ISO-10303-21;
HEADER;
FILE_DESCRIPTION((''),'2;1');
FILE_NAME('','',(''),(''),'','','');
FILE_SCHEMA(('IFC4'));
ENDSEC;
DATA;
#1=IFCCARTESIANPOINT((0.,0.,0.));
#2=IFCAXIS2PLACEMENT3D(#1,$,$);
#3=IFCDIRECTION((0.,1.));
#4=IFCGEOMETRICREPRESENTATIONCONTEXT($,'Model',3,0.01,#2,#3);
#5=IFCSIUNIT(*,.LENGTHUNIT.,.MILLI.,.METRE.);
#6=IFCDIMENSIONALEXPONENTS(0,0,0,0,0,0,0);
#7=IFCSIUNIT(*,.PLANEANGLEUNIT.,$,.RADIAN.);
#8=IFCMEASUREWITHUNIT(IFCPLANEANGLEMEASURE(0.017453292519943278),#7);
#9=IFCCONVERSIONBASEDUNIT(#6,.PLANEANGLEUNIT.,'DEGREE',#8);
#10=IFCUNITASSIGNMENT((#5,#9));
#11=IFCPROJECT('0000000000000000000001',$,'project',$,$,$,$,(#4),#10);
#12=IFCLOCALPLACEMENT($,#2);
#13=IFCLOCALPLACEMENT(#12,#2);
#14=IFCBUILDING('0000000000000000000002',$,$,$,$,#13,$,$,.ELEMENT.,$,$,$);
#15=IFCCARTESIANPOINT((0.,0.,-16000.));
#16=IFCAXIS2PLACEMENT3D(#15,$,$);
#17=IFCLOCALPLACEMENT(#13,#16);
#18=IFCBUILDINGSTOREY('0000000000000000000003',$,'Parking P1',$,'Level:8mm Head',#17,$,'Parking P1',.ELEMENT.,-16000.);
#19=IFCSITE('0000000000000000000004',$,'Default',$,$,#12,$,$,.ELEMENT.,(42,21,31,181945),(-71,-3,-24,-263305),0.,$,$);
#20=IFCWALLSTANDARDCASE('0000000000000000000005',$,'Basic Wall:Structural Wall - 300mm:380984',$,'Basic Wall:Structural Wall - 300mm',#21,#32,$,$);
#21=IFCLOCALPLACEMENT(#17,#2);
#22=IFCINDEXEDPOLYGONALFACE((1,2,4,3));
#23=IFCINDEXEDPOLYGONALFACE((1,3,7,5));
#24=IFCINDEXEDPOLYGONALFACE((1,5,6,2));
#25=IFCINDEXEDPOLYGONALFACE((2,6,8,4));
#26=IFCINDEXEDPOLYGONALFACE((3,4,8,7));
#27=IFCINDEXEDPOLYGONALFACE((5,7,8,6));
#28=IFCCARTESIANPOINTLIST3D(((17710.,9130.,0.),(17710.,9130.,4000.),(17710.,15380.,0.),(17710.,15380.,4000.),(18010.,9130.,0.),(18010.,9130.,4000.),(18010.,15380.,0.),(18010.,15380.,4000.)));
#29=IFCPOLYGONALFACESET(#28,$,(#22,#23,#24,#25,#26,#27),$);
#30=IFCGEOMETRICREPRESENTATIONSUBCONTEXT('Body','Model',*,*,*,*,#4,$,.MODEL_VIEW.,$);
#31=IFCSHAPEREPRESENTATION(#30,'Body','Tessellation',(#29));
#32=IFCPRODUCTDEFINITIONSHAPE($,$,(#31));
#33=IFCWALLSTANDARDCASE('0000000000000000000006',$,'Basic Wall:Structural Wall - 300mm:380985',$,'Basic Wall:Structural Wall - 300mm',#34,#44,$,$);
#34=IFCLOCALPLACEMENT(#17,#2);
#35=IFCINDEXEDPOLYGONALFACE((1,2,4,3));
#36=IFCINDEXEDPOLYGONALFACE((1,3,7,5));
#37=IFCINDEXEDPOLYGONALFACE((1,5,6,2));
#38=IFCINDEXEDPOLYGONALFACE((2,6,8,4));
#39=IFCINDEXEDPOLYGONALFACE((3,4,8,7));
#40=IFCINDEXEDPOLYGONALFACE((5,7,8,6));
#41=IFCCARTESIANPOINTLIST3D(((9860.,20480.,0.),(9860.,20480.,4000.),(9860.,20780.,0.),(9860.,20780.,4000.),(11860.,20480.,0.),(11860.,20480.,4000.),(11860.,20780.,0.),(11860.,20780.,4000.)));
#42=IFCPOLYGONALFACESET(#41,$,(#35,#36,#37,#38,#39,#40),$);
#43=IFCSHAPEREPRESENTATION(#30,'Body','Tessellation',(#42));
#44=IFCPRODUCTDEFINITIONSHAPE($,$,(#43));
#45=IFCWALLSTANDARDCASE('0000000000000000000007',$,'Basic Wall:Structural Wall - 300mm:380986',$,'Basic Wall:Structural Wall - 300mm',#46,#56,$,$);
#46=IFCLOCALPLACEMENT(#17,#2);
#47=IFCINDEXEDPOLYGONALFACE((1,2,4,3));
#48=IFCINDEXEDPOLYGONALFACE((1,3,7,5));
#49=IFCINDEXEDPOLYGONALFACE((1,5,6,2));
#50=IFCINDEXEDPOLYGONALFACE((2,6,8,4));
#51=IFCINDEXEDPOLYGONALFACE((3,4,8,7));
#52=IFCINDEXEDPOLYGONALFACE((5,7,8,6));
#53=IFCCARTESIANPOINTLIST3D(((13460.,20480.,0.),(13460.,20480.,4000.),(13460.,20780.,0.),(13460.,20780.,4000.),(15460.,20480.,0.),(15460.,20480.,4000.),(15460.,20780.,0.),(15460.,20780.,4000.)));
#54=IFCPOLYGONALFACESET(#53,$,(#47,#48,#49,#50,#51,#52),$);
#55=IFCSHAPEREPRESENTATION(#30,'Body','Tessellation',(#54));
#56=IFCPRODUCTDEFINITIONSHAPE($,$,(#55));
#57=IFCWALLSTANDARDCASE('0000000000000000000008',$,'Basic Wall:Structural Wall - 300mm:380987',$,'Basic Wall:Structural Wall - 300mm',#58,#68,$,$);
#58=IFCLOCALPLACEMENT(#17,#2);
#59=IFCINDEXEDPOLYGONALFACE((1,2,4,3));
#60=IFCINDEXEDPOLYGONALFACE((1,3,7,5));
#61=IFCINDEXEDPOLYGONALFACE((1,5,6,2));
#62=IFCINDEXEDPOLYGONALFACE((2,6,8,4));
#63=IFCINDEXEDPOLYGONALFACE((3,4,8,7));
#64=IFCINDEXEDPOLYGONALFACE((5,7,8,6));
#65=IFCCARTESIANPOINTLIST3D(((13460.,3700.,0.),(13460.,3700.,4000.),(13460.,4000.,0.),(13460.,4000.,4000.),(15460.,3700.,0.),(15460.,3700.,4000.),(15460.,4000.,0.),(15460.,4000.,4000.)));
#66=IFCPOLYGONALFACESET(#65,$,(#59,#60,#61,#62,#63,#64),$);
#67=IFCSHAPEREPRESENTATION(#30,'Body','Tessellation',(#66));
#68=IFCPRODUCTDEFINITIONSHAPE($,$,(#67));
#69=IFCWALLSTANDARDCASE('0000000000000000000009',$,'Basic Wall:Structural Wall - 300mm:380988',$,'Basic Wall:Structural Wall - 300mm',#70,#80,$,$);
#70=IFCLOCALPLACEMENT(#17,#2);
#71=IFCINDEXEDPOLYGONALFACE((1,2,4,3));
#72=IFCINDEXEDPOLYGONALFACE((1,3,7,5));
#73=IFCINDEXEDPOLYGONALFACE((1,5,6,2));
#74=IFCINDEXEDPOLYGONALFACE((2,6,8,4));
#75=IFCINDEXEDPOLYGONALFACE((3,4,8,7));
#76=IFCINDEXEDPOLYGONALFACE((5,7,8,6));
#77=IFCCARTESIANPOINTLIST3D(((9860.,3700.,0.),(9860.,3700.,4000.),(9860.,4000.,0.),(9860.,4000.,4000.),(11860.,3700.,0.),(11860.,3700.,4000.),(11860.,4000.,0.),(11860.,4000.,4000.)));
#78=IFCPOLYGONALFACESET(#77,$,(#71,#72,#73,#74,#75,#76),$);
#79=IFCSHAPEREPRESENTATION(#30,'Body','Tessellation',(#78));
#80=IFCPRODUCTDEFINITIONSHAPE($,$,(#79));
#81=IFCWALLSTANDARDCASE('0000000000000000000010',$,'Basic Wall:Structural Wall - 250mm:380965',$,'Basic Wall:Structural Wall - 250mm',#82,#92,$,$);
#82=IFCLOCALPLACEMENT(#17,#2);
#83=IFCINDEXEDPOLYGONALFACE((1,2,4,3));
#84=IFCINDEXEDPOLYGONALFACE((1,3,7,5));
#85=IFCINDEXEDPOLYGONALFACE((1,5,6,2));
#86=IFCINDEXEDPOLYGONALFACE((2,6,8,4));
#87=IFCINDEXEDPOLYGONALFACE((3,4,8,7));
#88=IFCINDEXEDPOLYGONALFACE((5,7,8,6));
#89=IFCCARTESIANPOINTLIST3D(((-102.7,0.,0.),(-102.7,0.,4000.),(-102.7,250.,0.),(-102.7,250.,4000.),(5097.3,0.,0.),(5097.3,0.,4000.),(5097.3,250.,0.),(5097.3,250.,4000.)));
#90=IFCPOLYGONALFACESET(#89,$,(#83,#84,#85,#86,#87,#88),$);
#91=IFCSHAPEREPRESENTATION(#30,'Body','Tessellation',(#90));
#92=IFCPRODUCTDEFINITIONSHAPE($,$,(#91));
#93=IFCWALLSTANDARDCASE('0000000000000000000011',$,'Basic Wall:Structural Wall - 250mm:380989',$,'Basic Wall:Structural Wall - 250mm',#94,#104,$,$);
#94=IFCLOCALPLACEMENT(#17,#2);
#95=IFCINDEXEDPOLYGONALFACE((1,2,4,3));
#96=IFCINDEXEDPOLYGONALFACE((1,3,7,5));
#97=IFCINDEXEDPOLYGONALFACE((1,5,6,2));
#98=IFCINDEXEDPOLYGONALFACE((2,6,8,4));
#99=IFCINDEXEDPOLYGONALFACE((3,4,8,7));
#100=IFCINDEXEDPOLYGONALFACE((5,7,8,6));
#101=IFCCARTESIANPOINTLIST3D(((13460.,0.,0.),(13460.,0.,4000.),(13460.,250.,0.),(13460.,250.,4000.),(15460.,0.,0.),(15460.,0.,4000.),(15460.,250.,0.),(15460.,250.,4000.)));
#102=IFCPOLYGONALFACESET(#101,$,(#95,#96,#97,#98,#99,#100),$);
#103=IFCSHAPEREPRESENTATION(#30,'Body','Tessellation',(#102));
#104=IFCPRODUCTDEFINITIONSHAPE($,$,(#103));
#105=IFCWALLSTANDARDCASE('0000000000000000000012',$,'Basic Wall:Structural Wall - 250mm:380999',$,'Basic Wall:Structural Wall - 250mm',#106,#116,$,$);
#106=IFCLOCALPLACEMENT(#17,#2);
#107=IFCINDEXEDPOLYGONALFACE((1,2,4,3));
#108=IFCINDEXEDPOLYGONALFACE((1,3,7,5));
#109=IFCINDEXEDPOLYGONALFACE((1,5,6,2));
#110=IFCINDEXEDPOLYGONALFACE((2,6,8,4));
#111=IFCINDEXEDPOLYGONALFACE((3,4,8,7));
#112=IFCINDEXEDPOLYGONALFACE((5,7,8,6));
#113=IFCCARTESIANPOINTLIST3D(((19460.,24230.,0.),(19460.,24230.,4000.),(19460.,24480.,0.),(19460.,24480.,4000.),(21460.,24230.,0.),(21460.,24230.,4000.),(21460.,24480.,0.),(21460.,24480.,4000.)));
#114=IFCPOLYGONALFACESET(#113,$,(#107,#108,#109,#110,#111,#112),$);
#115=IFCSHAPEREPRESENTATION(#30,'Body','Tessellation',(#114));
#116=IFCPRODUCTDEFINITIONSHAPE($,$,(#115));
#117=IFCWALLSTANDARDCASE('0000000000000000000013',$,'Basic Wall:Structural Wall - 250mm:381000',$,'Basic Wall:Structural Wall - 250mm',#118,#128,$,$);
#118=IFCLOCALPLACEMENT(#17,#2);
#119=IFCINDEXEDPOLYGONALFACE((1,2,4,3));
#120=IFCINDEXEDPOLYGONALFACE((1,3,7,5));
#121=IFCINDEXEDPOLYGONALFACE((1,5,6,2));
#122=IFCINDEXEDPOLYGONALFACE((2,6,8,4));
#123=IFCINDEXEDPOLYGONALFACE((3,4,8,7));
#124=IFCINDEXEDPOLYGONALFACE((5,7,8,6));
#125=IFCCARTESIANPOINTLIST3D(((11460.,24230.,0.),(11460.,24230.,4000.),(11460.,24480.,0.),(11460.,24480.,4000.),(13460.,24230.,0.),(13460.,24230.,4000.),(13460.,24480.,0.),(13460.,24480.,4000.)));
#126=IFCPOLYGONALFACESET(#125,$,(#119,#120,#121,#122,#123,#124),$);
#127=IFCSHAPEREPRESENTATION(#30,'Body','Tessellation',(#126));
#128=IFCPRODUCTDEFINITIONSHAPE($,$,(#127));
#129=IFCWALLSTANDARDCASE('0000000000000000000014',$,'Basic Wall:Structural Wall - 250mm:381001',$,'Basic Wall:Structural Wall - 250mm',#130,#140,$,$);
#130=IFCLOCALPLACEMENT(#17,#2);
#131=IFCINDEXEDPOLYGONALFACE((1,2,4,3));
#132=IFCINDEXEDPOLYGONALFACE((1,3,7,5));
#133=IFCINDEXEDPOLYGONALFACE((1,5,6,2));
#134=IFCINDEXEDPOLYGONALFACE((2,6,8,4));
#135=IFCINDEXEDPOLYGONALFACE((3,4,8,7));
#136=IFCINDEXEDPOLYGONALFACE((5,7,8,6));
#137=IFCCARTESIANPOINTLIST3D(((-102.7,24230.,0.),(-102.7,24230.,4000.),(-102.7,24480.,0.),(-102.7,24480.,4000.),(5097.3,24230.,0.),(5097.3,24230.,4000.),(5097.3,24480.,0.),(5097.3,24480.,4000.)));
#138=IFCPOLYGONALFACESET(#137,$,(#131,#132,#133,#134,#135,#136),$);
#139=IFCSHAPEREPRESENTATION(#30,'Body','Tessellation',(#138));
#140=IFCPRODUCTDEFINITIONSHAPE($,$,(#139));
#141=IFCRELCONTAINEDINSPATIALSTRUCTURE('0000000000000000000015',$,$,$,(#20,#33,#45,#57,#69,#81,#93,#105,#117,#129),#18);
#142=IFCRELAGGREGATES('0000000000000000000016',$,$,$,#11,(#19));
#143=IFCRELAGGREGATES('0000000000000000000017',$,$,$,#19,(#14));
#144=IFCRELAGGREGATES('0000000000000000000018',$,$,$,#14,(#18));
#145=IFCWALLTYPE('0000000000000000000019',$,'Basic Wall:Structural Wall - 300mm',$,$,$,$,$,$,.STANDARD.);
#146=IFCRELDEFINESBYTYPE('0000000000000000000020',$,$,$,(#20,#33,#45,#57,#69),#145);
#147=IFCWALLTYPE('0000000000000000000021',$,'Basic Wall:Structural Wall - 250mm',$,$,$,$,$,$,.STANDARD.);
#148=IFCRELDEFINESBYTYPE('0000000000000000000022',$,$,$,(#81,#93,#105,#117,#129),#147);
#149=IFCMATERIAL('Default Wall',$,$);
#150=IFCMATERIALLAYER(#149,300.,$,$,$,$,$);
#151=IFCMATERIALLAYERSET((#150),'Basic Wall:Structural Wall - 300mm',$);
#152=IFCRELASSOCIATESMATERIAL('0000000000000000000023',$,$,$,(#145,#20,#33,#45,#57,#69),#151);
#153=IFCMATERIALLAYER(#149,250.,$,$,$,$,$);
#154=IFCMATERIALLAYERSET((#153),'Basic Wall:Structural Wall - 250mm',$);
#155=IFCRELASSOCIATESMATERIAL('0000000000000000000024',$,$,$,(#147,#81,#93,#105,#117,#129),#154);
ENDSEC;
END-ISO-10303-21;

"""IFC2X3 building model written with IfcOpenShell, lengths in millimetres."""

from ifc_helpers import new_model, entity, si_unit, converted_unit, direction, frame, frame_2d, origin, place, context, subcontext, project, spatial, rectangle, extrude, material, layer, layer_set, layer_usage, type_object, element, save


model = new_model("IFC2X3")

# Units and contexts
model_context = context("Model", 3, precision=0.01, world=origin(), true_north=direction((0.0, 1.0)))
body_context = subcontext(model_context, "Body", "Model", "MODEL_VIEW")
ifc_project = project(units=[si_unit("LENGTHUNIT", "METRE", prefix="MILLI"), converted_unit("PLANEANGLEUNIT", "DEGREE", entity("IfcPlaneAngleMeasure", 0.017453292519943278), si_unit("PLANEANGLEUNIT", "RADIAN"), dimensions=[0, 0, 0, 0, 0, 0, 0])], contexts=[model_context])

# Site, building, storey
site_placement = place(None, origin())
site = spatial("IfcSite", under=ifc_project, at=site_placement, Name="Default", CompositionType="ELEMENT", RefLatitude=(42, 21, 31, 181945), RefLongitude=(-71, -3, -24, -263305), RefElevation=0.0)
building_placement = place(site_placement, origin())
building = spatial("IfcBuilding", under=site, at=building_placement, CompositionType="ELEMENT")
storey_placement = place(building_placement, frame((0.0, 0.0, -16000.0)))
storey = spatial("IfcBuildingStorey", under=building, at=storey_placement, Name="Parking P1", ObjectType="Level:8mm Head", LongName="Parking P1", CompositionType="ELEMENT", Elevation=-16000.0)

# Walls
ifc_material_1 = material(Name="Default Wall")
ifc_layer_1 = layer(ifc_material_1, 300.0)
ifc_layer_set_1 = layer_set([ifc_layer_1], Name="Basic Wall:Structural Wall - 300mm")
wall_type_1 = type_object("IfcWallType", Name="Basic Wall:Structural Wall - 300mm", PredefinedType="STANDARD", material=ifc_layer_set_1)
ifc_layer_usage_1 = layer_usage(ifc_layer_set_1, "AXIS2", "NEGATIVE", 150.0)
wall_1_placement = place(storey_placement, frame((17860.0, 15380.0, 0.0), z_axis=(0.0, 0.0, 1.0), x_axis=(0.0, -1.0, 0.0)))
element("IfcWallStandardCase", 1, at=wall_1_placement, inside=storey, type_object=wall_type_1, material=ifc_layer_usage_1, Name="Basic Wall:Structural Wall - 300mm:380984", ObjectType="Basic Wall:Structural Wall - 300mm", context=body_context, shape_type="SweptSolid", body=[
    extrude(rectangle(XDim=6250.0, YDim=300.0, at=frame_2d((3125.0, 0.0), x_axis=(-1.0, 0.0))), origin(), (0.0, 0.0, 1.0), 4000.0),
])
ifc_layer_usage_2 = layer_usage(ifc_layer_set_1, "AXIS2", "NEGATIVE", 150.0)
wall_2_placement = place(storey_placement, frame((9860.0, 20630.0, 0.0)))
element("IfcWallStandardCase", 2, at=wall_2_placement, inside=storey, type_object=wall_type_1, material=ifc_layer_usage_2, Name="Basic Wall:Structural Wall - 300mm:380985", ObjectType="Basic Wall:Structural Wall - 300mm", context=body_context, shape_type="SweptSolid", body=[
    extrude(rectangle(XDim=2000.0, YDim=300.0, at=frame_2d((1000.0, 0.0), x_axis=(-1.0, 0.0))), origin(), (0.0, 0.0, 1.0), 4000.0),
])
ifc_layer_usage_3 = layer_usage(ifc_layer_set_1, "AXIS2", "NEGATIVE", 150.0)
wall_3_placement = place(storey_placement, frame((13460.0, 20630.0, 0.0)))
element("IfcWallStandardCase", 3, at=wall_3_placement, inside=storey, type_object=wall_type_1, material=ifc_layer_usage_3, Name="Basic Wall:Structural Wall - 300mm:380986", ObjectType="Basic Wall:Structural Wall - 300mm", context=body_context, shape_type="SweptSolid", body=[
    extrude(rectangle(XDim=2000.0, YDim=300.0, at=frame_2d((1000.0, 0.0), x_axis=(-1.0, 0.0))), origin(), (0.0, 0.0, 1.0), 4000.0),
])
ifc_layer_usage_4 = layer_usage(ifc_layer_set_1, "AXIS2", "NEGATIVE", 150.0)
wall_4_placement = place(storey_placement, frame((13460.0, 3850.0, 0.0)))
element("IfcWallStandardCase", 4, at=wall_4_placement, inside=storey, type_object=wall_type_1, material=ifc_layer_usage_4, Name="Basic Wall:Structural Wall - 300mm:380987", ObjectType="Basic Wall:Structural Wall - 300mm", context=body_context, shape_type="SweptSolid", body=[
    extrude(rectangle(XDim=2000.0, YDim=300.0, at=frame_2d((1000.0, 0.0), x_axis=(-1.0, 0.0))), origin(), (0.0, 0.0, 1.0), 4000.0),
])
ifc_layer_usage_5 = layer_usage(ifc_layer_set_1, "AXIS2", "NEGATIVE", 150.0)
wall_5_placement = place(storey_placement, frame((9860.0, 3850.0, 0.0)))
element("IfcWallStandardCase", 5, at=wall_5_placement, inside=storey, type_object=wall_type_1, material=ifc_layer_usage_5, Name="Basic Wall:Structural Wall - 300mm:380988", ObjectType="Basic Wall:Structural Wall - 300mm", context=body_context, shape_type="SweptSolid", body=[
    extrude(rectangle(XDim=2000.0, YDim=300.0, at=frame_2d((1000.0, 0.0), x_axis=(-1.0, 0.0))), origin(), (0.0, 0.0, 1.0), 4000.0),
])
ifc_layer_2 = layer(ifc_material_1, 250.0)
ifc_layer_set_2 = layer_set([ifc_layer_2], Name="Basic Wall:Structural Wall - 250mm")
ifc_layer_usage_6 = layer_usage(ifc_layer_set_2, "AXIS2", "POSITIVE", -125.0)
wall_type_2 = type_object("IfcWallType", Name="Basic Wall:Structural Wall - 250mm", PredefinedType="STANDARD", material=ifc_layer_set_2)
wall_6_placement = place(storey_placement, frame((-102.7, 125.0, 0.0)))
element("IfcWallStandardCase", 6, at=wall_6_placement, inside=storey, type_object=wall_type_2, material=ifc_layer_usage_6, Name="Basic Wall:Structural Wall - 250mm:380965", ObjectType="Basic Wall:Structural Wall - 250mm", context=body_context, shape_type="SweptSolid", body=[
    extrude(rectangle(XDim=5200.0, YDim=250.0, at=frame_2d((2600.0, 0.0), x_axis=(-1.0, 0.0))), origin(), (0.0, 0.0, 1.0), 4000.0),
])
ifc_layer_usage_7 = layer_usage(ifc_layer_set_2, "AXIS2", "NEGATIVE", 125.0)
wall_7_placement = place(storey_placement, frame((15460.0, 125.0, 0.0), z_axis=(0.0, 0.0, 1.0), x_axis=(-1.0, 0.0, 0.0)))
element("IfcWallStandardCase", 7, at=wall_7_placement, inside=storey, type_object=wall_type_2, material=ifc_layer_usage_7, Name="Basic Wall:Structural Wall - 250mm:380989", ObjectType="Basic Wall:Structural Wall - 250mm", context=body_context, shape_type="SweptSolid", body=[
    extrude(rectangle(XDim=2000.0, YDim=250.0, at=frame_2d((1000.0, 0.0), x_axis=(-1.0, 0.0))), origin(), (0.0, 0.0, 1.0), 4000.0),
])
ifc_layer_usage_8 = layer_usage(ifc_layer_set_2, "AXIS2", "NEGATIVE", 125.0)
wall_8_placement = place(storey_placement, frame((19460.0, 24355.0, 0.0)))
element("IfcWallStandardCase", 8, at=wall_8_placement, inside=storey, type_object=wall_type_2, material=ifc_layer_usage_8, Name="Basic Wall:Structural Wall - 250mm:380999", ObjectType="Basic Wall:Structural Wall - 250mm", context=body_context, shape_type="SweptSolid", body=[
    extrude(rectangle(XDim=2000.0, YDim=250.0, at=frame_2d((1000.0, 0.0), x_axis=(-1.0, 0.0))), origin(), (0.0, 0.0, 1.0), 4000.0),
])
ifc_layer_usage_9 = layer_usage(ifc_layer_set_2, "AXIS2", "NEGATIVE", 125.0)
wall_9_placement = place(storey_placement, frame((11460.0, 24355.0, 0.0)))
element("IfcWallStandardCase", 9, at=wall_9_placement, inside=storey, type_object=wall_type_2, material=ifc_layer_usage_9, Name="Basic Wall:Structural Wall - 250mm:381000", ObjectType="Basic Wall:Structural Wall - 250mm", context=body_context, shape_type="SweptSolid", body=[
    extrude(rectangle(XDim=2000.0, YDim=250.0, at=frame_2d((1000.0, 0.0), x_axis=(-1.0, 0.0))), origin(), (0.0, 0.0, 1.0), 4000.0),
])
ifc_layer_usage_10 = layer_usage(ifc_layer_set_2, "AXIS2", "NEGATIVE", 125.0)
wall_10_placement = place(storey_placement, frame((-102.7, 24355.0, 0.0)))
element("IfcWallStandardCase", 10, at=wall_10_placement, inside=storey, type_object=wall_type_2, material=ifc_layer_usage_10, Name="Basic Wall:Structural Wall - 250mm:381001", ObjectType="Basic Wall:Structural Wall - 250mm", context=body_context, shape_type="SweptSolid", body=[
    extrude(rectangle(XDim=5200.0, YDim=250.0, at=frame_2d((2600.0, 0.0), x_axis=(-1.0, 0.0))), origin(), (0.0, 0.0, 1.0), 4000.0),
])

save(model, "model.ifc")
